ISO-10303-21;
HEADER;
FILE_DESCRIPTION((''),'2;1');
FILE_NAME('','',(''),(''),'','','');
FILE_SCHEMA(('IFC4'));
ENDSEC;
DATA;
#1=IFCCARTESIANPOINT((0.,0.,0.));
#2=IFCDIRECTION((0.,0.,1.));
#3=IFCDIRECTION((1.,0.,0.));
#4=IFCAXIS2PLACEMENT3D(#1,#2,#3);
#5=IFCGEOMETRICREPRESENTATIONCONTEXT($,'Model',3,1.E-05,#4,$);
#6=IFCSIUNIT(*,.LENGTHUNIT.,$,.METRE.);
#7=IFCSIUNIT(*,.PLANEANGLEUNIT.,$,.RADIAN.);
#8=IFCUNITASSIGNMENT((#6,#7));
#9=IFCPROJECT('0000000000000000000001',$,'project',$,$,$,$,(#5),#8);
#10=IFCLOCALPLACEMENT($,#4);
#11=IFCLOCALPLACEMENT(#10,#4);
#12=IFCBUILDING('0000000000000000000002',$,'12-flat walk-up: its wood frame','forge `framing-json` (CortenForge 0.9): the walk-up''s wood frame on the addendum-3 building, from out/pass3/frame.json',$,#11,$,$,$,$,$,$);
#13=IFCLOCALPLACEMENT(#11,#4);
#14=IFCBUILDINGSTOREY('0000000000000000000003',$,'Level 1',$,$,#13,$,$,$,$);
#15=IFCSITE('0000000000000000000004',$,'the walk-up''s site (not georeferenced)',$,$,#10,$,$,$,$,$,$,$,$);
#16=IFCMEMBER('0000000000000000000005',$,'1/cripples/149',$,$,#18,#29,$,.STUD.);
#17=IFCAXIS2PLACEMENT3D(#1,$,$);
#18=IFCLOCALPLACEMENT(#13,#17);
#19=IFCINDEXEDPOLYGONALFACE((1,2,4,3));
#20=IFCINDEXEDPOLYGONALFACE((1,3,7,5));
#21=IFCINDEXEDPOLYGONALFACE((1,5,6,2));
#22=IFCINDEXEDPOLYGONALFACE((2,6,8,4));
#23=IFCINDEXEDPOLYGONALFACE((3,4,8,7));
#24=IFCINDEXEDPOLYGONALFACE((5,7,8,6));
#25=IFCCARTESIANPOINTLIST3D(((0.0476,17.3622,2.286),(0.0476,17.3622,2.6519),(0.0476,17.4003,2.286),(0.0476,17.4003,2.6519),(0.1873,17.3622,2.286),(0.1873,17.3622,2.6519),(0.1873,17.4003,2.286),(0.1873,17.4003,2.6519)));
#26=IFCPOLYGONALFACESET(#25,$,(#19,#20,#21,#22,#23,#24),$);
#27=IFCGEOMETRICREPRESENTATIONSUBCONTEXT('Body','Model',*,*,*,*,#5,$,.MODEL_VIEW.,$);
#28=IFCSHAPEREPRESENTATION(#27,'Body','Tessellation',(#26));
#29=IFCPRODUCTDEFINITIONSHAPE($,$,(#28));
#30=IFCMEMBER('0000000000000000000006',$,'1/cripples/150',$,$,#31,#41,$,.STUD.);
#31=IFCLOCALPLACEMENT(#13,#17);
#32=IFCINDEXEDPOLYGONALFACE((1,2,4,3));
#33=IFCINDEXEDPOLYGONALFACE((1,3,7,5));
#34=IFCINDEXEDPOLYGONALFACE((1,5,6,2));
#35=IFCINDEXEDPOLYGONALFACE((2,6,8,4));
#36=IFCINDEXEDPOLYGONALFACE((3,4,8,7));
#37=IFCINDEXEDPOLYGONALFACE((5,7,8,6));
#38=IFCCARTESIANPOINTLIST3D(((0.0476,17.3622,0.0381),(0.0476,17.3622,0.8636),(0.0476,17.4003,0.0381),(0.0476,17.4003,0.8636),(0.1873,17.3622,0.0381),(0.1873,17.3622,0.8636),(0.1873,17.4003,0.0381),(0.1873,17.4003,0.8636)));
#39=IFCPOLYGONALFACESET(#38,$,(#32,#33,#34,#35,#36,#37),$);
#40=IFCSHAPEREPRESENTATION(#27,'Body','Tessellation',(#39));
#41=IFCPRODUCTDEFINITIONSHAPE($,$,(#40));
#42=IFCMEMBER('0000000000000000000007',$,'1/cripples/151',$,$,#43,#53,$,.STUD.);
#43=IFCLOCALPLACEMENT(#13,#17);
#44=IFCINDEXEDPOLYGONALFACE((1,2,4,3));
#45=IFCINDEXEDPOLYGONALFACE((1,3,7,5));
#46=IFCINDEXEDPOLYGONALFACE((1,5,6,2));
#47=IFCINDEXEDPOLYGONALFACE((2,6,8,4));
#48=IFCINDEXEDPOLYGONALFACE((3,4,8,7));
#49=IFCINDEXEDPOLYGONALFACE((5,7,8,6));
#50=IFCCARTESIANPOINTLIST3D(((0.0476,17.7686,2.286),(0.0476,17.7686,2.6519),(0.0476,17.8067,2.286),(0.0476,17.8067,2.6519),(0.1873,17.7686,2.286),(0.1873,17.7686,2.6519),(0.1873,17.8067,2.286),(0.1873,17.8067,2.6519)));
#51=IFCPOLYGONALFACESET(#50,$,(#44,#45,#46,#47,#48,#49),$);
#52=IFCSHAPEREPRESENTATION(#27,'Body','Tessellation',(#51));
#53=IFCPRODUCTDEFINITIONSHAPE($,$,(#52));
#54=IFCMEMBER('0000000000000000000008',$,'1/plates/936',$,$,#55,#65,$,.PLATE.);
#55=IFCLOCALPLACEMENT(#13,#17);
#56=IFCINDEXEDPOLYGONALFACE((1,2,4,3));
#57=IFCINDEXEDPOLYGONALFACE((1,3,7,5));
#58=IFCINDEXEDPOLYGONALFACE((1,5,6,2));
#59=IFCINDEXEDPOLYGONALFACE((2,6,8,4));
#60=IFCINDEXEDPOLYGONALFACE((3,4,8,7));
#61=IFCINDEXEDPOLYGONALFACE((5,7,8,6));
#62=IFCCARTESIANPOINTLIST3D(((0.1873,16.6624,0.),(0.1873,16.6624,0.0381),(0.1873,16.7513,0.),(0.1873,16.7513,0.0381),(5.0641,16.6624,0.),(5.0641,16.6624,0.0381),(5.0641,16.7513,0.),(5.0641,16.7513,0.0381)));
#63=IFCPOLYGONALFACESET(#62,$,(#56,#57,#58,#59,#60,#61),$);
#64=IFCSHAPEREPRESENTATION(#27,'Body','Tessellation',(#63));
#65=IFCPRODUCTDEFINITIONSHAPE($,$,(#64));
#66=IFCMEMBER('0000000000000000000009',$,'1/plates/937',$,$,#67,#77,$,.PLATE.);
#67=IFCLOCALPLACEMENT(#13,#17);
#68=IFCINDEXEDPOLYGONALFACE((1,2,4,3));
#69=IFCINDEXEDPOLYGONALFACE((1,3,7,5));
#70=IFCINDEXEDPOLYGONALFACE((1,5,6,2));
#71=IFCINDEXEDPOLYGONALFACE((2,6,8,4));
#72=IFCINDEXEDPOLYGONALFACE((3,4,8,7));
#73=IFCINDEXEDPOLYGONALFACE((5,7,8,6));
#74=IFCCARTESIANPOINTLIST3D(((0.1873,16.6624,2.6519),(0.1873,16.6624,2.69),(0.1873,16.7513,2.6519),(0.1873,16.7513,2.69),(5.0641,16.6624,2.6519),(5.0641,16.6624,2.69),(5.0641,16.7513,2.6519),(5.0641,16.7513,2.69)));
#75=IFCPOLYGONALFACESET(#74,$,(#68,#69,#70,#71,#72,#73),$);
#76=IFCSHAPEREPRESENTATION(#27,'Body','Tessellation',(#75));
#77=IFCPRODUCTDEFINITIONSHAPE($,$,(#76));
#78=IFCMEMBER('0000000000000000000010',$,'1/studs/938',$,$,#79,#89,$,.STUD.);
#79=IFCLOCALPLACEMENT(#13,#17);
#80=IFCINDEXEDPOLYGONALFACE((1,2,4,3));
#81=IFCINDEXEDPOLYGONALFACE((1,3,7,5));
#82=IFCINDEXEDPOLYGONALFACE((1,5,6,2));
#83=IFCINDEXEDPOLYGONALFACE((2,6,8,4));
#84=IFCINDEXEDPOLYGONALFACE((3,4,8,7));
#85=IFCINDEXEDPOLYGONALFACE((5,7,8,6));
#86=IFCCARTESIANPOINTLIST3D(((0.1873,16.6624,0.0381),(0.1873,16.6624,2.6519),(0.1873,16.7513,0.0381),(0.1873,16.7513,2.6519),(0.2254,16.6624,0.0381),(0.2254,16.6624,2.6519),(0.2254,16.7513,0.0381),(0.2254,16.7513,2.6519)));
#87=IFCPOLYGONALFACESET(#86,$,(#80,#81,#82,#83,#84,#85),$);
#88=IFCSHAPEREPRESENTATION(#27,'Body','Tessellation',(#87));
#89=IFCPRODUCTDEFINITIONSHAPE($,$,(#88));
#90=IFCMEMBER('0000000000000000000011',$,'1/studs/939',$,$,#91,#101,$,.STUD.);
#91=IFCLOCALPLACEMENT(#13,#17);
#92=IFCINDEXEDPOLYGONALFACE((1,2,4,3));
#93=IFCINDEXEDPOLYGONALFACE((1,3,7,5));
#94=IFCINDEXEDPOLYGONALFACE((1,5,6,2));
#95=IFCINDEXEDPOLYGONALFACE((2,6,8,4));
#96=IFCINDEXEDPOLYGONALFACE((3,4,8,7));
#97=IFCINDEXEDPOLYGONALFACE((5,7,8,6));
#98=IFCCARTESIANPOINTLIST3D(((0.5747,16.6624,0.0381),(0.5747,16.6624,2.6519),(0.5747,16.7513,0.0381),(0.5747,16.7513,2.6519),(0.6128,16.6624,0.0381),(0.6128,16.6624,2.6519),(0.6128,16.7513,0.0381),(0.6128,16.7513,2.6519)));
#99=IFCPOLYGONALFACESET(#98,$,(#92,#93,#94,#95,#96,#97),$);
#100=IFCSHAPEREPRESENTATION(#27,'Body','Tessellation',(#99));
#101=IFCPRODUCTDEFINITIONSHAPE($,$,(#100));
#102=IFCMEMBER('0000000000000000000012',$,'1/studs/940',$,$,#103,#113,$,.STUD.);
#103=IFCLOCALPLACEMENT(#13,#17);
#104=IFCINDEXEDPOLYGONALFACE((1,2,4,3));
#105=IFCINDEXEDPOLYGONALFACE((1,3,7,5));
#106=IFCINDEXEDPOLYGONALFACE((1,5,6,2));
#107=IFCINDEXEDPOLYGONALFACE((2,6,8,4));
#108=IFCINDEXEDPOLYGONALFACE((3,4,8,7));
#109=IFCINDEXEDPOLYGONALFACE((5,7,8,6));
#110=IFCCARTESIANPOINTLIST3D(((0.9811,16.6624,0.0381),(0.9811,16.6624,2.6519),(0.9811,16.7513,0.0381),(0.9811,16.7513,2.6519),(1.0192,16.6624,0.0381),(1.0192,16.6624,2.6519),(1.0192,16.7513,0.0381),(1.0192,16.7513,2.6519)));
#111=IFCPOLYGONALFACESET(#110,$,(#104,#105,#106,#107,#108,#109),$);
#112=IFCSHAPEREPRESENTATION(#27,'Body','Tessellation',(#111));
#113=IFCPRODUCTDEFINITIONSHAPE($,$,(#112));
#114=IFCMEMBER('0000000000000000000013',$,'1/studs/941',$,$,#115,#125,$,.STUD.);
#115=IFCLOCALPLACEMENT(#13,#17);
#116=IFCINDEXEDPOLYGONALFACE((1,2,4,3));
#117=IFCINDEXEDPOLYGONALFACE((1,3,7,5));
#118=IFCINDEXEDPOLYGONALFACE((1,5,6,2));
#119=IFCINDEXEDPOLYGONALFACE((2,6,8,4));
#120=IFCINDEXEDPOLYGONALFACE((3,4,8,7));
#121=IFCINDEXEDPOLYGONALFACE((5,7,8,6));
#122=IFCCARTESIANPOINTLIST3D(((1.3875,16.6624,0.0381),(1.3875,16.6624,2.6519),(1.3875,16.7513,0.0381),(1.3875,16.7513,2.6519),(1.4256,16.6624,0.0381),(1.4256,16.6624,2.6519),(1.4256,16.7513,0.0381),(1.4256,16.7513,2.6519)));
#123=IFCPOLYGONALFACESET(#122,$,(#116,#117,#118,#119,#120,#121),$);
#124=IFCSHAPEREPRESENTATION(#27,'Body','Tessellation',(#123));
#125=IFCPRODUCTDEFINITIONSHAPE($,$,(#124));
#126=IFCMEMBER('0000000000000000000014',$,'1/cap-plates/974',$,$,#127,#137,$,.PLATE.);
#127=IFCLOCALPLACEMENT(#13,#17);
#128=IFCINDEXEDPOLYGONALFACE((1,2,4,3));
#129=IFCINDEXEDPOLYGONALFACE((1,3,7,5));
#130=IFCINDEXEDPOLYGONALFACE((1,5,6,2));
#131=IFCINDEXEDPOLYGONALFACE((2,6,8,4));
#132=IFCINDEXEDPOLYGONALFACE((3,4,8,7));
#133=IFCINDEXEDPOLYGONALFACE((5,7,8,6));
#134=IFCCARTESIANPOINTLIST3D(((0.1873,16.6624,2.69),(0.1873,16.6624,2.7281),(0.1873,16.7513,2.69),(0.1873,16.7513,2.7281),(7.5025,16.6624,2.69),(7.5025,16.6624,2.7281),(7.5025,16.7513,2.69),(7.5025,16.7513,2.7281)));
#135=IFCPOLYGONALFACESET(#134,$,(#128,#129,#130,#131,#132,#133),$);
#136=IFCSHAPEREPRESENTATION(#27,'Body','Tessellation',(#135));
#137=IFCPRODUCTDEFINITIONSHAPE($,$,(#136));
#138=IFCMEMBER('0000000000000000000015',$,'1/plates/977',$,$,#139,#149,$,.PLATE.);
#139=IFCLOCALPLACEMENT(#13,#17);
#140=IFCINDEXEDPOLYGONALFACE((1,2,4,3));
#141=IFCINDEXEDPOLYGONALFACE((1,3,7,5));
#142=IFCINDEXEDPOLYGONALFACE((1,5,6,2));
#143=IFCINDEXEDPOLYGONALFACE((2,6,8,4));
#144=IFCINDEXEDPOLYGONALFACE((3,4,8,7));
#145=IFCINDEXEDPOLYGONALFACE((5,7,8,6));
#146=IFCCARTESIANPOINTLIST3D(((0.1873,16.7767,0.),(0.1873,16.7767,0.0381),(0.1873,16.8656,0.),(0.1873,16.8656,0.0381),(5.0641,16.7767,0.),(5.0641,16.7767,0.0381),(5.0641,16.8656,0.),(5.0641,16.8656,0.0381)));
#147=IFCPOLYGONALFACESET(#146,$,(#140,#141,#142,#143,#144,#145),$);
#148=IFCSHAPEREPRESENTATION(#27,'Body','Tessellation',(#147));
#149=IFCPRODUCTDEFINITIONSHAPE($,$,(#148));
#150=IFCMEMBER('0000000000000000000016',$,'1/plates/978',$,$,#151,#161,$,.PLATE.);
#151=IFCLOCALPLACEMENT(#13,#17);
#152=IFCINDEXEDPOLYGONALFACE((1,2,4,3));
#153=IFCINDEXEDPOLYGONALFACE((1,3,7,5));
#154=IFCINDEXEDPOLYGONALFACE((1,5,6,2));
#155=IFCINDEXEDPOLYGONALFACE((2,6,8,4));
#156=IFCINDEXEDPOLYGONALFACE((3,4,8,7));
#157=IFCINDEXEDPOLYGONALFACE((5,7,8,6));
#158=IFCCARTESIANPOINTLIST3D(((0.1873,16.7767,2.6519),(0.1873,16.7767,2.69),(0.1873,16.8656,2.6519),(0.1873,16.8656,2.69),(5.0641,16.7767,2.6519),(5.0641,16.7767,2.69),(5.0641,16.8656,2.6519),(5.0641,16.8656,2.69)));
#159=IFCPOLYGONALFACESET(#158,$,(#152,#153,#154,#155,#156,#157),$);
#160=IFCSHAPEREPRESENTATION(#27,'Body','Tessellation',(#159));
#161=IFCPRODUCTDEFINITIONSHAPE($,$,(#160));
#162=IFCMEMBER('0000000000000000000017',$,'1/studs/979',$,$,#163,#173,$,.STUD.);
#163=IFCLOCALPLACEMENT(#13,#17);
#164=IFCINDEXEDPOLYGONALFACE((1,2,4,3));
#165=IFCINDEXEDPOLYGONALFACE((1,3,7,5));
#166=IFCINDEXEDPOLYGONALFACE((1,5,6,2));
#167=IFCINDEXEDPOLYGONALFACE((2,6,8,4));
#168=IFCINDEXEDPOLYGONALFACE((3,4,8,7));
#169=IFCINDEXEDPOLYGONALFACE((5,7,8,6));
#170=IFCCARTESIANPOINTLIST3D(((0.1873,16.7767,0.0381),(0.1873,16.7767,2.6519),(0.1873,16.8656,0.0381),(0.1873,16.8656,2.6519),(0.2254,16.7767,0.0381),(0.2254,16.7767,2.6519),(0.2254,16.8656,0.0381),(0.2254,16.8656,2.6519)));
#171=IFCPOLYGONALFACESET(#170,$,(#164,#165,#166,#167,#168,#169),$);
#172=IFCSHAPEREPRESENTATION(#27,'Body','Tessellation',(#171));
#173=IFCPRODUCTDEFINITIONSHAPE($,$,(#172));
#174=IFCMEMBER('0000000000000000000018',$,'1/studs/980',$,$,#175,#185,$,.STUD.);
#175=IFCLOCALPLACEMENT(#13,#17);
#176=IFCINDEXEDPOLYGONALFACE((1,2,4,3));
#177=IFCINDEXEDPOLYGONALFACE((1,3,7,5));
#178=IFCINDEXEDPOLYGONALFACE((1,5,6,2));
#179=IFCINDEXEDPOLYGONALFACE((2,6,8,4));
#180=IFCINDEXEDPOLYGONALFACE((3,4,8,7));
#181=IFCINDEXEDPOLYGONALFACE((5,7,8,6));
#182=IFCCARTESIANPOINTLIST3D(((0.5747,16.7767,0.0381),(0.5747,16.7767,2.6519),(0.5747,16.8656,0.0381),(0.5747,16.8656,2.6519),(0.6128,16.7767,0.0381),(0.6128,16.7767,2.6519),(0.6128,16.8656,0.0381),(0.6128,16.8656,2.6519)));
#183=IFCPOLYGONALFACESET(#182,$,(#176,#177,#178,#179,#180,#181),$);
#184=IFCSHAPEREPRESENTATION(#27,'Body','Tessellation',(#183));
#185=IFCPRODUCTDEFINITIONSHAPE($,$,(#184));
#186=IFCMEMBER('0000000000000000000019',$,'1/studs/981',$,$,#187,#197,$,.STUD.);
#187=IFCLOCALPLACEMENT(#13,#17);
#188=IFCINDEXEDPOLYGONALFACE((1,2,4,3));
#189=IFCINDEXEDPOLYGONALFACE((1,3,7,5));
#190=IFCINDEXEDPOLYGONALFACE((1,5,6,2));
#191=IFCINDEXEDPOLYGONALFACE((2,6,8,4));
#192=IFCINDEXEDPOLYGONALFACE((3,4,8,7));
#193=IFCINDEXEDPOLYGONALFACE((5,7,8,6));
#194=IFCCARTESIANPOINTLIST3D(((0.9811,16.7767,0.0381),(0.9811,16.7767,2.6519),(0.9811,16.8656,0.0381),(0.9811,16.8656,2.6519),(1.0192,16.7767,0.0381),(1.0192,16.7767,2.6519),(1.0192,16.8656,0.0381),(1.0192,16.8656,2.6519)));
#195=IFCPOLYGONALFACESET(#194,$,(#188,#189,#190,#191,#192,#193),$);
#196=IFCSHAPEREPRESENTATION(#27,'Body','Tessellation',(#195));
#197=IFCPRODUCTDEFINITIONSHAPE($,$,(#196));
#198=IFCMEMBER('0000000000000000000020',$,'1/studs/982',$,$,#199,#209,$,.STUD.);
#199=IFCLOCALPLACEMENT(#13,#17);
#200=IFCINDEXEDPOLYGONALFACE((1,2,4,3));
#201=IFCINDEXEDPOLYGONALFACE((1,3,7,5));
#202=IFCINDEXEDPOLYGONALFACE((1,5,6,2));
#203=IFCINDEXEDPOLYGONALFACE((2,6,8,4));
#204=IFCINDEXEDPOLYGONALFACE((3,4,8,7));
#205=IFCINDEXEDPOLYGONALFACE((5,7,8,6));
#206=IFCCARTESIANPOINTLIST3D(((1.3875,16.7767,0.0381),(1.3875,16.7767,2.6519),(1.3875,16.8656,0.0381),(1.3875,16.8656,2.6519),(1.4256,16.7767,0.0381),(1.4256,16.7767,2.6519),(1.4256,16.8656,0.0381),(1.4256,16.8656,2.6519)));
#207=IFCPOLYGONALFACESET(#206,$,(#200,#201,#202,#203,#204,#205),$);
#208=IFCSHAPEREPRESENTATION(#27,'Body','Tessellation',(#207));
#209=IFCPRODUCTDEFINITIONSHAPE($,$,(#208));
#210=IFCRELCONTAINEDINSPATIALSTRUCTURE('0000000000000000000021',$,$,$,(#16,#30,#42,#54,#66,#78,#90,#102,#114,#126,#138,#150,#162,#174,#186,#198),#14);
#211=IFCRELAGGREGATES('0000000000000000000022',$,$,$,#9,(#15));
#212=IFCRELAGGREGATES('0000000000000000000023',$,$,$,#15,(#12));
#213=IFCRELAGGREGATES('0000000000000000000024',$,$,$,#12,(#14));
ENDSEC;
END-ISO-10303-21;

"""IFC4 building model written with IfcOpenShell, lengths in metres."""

from ifc_helpers import new_model, si_unit, frame, frame_2d, origin, origin_with_axes, place, context, subcontext, project, spatial, rectangle, extrude, element, save


model = new_model("IFC4")

# Units and contexts
model_context = context("Model", 3, precision=1e-05, world=origin_with_axes())
body_context = subcontext(model_context, "Body", "Model", "MODEL_VIEW")
ifc_project = project(units=[si_unit("LENGTHUNIT", "METRE"), si_unit("PLANEANGLEUNIT", "RADIAN")], contexts=[model_context])

# Site, building, storey
site_placement = place(None, origin_with_axes())
site = spatial("IfcSite", under=ifc_project, at=site_placement, Name="the walk-up's site (not georeferenced)")
building_placement = place(site_placement, origin_with_axes())
building = spatial("IfcBuilding", under=site, at=building_placement, Name="12-flat walk-up: its wood frame", Description="forge `framing-json` (CortenForge 0.9): the walk-up's wood frame on the addendum-3 building, from out/pass3/frame.json")
storey_placement = place(building_placement, origin_with_axes())
storey = spatial("IfcBuildingStorey", under=building, at=storey_placement, Name="Level 1")

# Members
member_1_placement = place(storey_placement, frame((0.0476, 17.3622, 2.286), z_axis=(0.0, 0.0, 1.0), x_axis=(1.0, 0.0, 0.0)))
element("IfcMember", 1, at=member_1_placement, inside=storey, Name="1/cripples/149", PredefinedType="STUD", context=body_context, shape_type="SweptSolid", body=[
    extrude(rectangle(XDim=0.1397, YDim=0.0381, at=frame_2d((0.0698, 0.0191))), origin(), (0.0, 0.0, 1.0), 0.3659),
])
member_2_placement = place(storey_placement, frame((0.0476, 17.3622, 0.0381), z_axis=(0.0, 0.0, 1.0), x_axis=(1.0, 0.0, 0.0)))
element("IfcMember", 2, at=member_2_placement, inside=storey, Name="1/cripples/150", PredefinedType="STUD", context=body_context, shape_type="SweptSolid", body=[
    extrude(rectangle(XDim=0.1397, YDim=0.0381, at=frame_2d((0.0698, 0.0191))), origin(), (0.0, 0.0, 1.0), 0.8255),
])
member_3_placement = place(storey_placement, frame((0.0476, 17.7686, 2.286), z_axis=(0.0, 0.0, 1.0), x_axis=(1.0, 0.0, 0.0)))
element("IfcMember", 3, at=member_3_placement, inside=storey, Name="1/cripples/151", PredefinedType="STUD", context=body_context, shape_type="SweptSolid", body=[
    extrude(rectangle(XDim=0.1397, YDim=0.0381, at=frame_2d((0.0698, 0.0191))), origin(), (0.0, 0.0, 1.0), 0.3659),
])
member_4_placement = place(storey_placement, frame((0.1873, 16.6624, 0.0), z_axis=(0.0, 0.0, 1.0), x_axis=(1.0, 0.0, 0.0)))
element("IfcMember", 4, at=member_4_placement, inside=storey, Name="1/plates/936", PredefinedType="PLATE", context=body_context, shape_type="SweptSolid", body=[
    extrude(rectangle(XDim=4.8768, YDim=0.0889, at=frame_2d((2.4384, 0.0444))), origin(), (0.0, 0.0, 1.0), 0.0381),
])
member_5_placement = place(storey_placement, frame((0.1873, 16.6624, 2.6519), z_axis=(0.0, 0.0, 1.0), x_axis=(1.0, 0.0, 0.0)))
element("IfcMember", 5, at=member_5_placement, inside=storey, Name="1/plates/937", PredefinedType="PLATE", context=body_context, shape_type="SweptSolid", body=[
    extrude(rectangle(XDim=4.8768, YDim=0.0889, at=frame_2d((2.4384, 0.0444))), origin(), (0.0, 0.0, 1.0), 0.0381),
])
member_6_placement = place(storey_placement, frame((0.1873, 16.6624, 0.0381), z_axis=(0.0, 0.0, 1.0), x_axis=(1.0, 0.0, 0.0)))
element("IfcMember", 6, at=member_6_placement, inside=storey, Name="1/studs/938", PredefinedType="STUD", context=body_context, shape_type="SweptSolid", body=[
    extrude(rectangle(XDim=0.0381, YDim=0.0889, at=frame_2d((0.019, 0.0444))), origin(), (0.0, 0.0, 1.0), 2.6138),
])
for number, where, z_axis, x_axis, name in (
    (7, (0.5747, 16.6624, 0.0381), (0.0, 0.0, 1.0), (1.0, 0.0, 0.0), "1/studs/939"),
    (8, (0.9811, 16.6624, 0.0381), (0.0, 0.0, 1.0), (1.0, 0.0, 0.0), "1/studs/940"),
):
    element("IfcMember", number, at=place(storey_placement, frame(where, z_axis=z_axis, x_axis=x_axis)), inside=storey, Name=name, PredefinedType="STUD", context=body_context, shape_type="SweptSolid", body=[
        extrude(rectangle(XDim=0.0381, YDim=0.0889, at=frame_2d((0.019, 0.0444))), origin(), (0.0, 0.0, 1.0), 2.6138),
    ])
member_7_placement = place(storey_placement, frame((1.3875, 16.6624, 0.0381), z_axis=(0.0, 0.0, 1.0), x_axis=(1.0, 0.0, 0.0)))
element("IfcMember", 9, at=member_7_placement, inside=storey, Name="1/studs/941", PredefinedType="STUD", context=body_context, shape_type="SweptSolid", body=[
    extrude(rectangle(XDim=0.0381, YDim=0.0889, at=frame_2d((0.0191, 0.0444))), origin(), (0.0, 0.0, 1.0), 2.6138),
])
member_8_placement = place(storey_placement, frame((0.1873, 16.6624, 2.69), z_axis=(0.0, 0.0, 1.0), x_axis=(1.0, 0.0, 0.0)))
element("IfcMember", 10, at=member_8_placement, inside=storey, Name="1/cap-plates/974", PredefinedType="PLATE", context=body_context, shape_type="SweptSolid", body=[
    extrude(rectangle(XDim=7.3152, YDim=0.0889, at=frame_2d((3.6576, 0.0444))), origin(), (0.0, 0.0, 1.0), 0.0381),
])
member_9_placement = place(storey_placement, frame((0.1873, 16.7767, 0.0), z_axis=(0.0, 0.0, 1.0), x_axis=(1.0, 0.0, 0.0)))
element("IfcMember", 11, at=member_9_placement, inside=storey, Name="1/plates/977", PredefinedType="PLATE", context=body_context, shape_type="SweptSolid", body=[
    extrude(rectangle(XDim=4.8768, YDim=0.0889, at=frame_2d((2.4384, 0.0444))), origin(), (0.0, 0.0, 1.0), 0.0381),
])
member_10_placement = place(storey_placement, frame((0.1873, 16.7767, 2.6519), z_axis=(0.0, 0.0, 1.0), x_axis=(1.0, 0.0, 0.0)))
element("IfcMember", 12, at=member_10_placement, inside=storey, Name="1/plates/978", PredefinedType="PLATE", context=body_context, shape_type="SweptSolid", body=[
    extrude(rectangle(XDim=4.8768, YDim=0.0889, at=frame_2d((2.4384, 0.0444))), origin(), (0.0, 0.0, 1.0), 0.0381),
])
member_11_placement = place(storey_placement, frame((0.1873, 16.7767, 0.0381), z_axis=(0.0, 0.0, 1.0), x_axis=(1.0, 0.0, 0.0)))
element("IfcMember", 13, at=member_11_placement, inside=storey, Name="1/studs/979", PredefinedType="STUD", context=body_context, shape_type="SweptSolid", body=[
    extrude(rectangle(XDim=0.0381, YDim=0.0889, at=frame_2d((0.019, 0.0444))), origin(), (0.0, 0.0, 1.0), 2.6138),
])
for number, where, z_axis, x_axis, name in (
    (14, (0.5747, 16.7767, 0.0381), (0.0, 0.0, 1.0), (1.0, 0.0, 0.0), "1/studs/980"),
    (15, (0.9811, 16.7767, 0.0381), (0.0, 0.0, 1.0), (1.0, 0.0, 0.0), "1/studs/981"),
):
    element("IfcMember", number, at=place(storey_placement, frame(where, z_axis=z_axis, x_axis=x_axis)), inside=storey, Name=name, PredefinedType="STUD", context=body_context, shape_type="SweptSolid", body=[
        extrude(rectangle(XDim=0.0381, YDim=0.0889, at=frame_2d((0.019, 0.0444))), origin(), (0.0, 0.0, 1.0), 2.6138),
    ])
member_12_placement = place(storey_placement, frame((1.3875, 16.7767, 0.0381), z_axis=(0.0, 0.0, 1.0), x_axis=(1.0, 0.0, 0.0)))
element("IfcMember", 16, at=member_12_placement, inside=storey, Name="1/studs/982", PredefinedType="STUD", context=body_context, shape_type="SweptSolid", body=[
    extrude(rectangle(XDim=0.0381, YDim=0.0889, at=frame_2d((0.0191, 0.0444))), origin(), (0.0, 0.0, 1.0), 2.6138),
])

save(model, "model.ifc")
